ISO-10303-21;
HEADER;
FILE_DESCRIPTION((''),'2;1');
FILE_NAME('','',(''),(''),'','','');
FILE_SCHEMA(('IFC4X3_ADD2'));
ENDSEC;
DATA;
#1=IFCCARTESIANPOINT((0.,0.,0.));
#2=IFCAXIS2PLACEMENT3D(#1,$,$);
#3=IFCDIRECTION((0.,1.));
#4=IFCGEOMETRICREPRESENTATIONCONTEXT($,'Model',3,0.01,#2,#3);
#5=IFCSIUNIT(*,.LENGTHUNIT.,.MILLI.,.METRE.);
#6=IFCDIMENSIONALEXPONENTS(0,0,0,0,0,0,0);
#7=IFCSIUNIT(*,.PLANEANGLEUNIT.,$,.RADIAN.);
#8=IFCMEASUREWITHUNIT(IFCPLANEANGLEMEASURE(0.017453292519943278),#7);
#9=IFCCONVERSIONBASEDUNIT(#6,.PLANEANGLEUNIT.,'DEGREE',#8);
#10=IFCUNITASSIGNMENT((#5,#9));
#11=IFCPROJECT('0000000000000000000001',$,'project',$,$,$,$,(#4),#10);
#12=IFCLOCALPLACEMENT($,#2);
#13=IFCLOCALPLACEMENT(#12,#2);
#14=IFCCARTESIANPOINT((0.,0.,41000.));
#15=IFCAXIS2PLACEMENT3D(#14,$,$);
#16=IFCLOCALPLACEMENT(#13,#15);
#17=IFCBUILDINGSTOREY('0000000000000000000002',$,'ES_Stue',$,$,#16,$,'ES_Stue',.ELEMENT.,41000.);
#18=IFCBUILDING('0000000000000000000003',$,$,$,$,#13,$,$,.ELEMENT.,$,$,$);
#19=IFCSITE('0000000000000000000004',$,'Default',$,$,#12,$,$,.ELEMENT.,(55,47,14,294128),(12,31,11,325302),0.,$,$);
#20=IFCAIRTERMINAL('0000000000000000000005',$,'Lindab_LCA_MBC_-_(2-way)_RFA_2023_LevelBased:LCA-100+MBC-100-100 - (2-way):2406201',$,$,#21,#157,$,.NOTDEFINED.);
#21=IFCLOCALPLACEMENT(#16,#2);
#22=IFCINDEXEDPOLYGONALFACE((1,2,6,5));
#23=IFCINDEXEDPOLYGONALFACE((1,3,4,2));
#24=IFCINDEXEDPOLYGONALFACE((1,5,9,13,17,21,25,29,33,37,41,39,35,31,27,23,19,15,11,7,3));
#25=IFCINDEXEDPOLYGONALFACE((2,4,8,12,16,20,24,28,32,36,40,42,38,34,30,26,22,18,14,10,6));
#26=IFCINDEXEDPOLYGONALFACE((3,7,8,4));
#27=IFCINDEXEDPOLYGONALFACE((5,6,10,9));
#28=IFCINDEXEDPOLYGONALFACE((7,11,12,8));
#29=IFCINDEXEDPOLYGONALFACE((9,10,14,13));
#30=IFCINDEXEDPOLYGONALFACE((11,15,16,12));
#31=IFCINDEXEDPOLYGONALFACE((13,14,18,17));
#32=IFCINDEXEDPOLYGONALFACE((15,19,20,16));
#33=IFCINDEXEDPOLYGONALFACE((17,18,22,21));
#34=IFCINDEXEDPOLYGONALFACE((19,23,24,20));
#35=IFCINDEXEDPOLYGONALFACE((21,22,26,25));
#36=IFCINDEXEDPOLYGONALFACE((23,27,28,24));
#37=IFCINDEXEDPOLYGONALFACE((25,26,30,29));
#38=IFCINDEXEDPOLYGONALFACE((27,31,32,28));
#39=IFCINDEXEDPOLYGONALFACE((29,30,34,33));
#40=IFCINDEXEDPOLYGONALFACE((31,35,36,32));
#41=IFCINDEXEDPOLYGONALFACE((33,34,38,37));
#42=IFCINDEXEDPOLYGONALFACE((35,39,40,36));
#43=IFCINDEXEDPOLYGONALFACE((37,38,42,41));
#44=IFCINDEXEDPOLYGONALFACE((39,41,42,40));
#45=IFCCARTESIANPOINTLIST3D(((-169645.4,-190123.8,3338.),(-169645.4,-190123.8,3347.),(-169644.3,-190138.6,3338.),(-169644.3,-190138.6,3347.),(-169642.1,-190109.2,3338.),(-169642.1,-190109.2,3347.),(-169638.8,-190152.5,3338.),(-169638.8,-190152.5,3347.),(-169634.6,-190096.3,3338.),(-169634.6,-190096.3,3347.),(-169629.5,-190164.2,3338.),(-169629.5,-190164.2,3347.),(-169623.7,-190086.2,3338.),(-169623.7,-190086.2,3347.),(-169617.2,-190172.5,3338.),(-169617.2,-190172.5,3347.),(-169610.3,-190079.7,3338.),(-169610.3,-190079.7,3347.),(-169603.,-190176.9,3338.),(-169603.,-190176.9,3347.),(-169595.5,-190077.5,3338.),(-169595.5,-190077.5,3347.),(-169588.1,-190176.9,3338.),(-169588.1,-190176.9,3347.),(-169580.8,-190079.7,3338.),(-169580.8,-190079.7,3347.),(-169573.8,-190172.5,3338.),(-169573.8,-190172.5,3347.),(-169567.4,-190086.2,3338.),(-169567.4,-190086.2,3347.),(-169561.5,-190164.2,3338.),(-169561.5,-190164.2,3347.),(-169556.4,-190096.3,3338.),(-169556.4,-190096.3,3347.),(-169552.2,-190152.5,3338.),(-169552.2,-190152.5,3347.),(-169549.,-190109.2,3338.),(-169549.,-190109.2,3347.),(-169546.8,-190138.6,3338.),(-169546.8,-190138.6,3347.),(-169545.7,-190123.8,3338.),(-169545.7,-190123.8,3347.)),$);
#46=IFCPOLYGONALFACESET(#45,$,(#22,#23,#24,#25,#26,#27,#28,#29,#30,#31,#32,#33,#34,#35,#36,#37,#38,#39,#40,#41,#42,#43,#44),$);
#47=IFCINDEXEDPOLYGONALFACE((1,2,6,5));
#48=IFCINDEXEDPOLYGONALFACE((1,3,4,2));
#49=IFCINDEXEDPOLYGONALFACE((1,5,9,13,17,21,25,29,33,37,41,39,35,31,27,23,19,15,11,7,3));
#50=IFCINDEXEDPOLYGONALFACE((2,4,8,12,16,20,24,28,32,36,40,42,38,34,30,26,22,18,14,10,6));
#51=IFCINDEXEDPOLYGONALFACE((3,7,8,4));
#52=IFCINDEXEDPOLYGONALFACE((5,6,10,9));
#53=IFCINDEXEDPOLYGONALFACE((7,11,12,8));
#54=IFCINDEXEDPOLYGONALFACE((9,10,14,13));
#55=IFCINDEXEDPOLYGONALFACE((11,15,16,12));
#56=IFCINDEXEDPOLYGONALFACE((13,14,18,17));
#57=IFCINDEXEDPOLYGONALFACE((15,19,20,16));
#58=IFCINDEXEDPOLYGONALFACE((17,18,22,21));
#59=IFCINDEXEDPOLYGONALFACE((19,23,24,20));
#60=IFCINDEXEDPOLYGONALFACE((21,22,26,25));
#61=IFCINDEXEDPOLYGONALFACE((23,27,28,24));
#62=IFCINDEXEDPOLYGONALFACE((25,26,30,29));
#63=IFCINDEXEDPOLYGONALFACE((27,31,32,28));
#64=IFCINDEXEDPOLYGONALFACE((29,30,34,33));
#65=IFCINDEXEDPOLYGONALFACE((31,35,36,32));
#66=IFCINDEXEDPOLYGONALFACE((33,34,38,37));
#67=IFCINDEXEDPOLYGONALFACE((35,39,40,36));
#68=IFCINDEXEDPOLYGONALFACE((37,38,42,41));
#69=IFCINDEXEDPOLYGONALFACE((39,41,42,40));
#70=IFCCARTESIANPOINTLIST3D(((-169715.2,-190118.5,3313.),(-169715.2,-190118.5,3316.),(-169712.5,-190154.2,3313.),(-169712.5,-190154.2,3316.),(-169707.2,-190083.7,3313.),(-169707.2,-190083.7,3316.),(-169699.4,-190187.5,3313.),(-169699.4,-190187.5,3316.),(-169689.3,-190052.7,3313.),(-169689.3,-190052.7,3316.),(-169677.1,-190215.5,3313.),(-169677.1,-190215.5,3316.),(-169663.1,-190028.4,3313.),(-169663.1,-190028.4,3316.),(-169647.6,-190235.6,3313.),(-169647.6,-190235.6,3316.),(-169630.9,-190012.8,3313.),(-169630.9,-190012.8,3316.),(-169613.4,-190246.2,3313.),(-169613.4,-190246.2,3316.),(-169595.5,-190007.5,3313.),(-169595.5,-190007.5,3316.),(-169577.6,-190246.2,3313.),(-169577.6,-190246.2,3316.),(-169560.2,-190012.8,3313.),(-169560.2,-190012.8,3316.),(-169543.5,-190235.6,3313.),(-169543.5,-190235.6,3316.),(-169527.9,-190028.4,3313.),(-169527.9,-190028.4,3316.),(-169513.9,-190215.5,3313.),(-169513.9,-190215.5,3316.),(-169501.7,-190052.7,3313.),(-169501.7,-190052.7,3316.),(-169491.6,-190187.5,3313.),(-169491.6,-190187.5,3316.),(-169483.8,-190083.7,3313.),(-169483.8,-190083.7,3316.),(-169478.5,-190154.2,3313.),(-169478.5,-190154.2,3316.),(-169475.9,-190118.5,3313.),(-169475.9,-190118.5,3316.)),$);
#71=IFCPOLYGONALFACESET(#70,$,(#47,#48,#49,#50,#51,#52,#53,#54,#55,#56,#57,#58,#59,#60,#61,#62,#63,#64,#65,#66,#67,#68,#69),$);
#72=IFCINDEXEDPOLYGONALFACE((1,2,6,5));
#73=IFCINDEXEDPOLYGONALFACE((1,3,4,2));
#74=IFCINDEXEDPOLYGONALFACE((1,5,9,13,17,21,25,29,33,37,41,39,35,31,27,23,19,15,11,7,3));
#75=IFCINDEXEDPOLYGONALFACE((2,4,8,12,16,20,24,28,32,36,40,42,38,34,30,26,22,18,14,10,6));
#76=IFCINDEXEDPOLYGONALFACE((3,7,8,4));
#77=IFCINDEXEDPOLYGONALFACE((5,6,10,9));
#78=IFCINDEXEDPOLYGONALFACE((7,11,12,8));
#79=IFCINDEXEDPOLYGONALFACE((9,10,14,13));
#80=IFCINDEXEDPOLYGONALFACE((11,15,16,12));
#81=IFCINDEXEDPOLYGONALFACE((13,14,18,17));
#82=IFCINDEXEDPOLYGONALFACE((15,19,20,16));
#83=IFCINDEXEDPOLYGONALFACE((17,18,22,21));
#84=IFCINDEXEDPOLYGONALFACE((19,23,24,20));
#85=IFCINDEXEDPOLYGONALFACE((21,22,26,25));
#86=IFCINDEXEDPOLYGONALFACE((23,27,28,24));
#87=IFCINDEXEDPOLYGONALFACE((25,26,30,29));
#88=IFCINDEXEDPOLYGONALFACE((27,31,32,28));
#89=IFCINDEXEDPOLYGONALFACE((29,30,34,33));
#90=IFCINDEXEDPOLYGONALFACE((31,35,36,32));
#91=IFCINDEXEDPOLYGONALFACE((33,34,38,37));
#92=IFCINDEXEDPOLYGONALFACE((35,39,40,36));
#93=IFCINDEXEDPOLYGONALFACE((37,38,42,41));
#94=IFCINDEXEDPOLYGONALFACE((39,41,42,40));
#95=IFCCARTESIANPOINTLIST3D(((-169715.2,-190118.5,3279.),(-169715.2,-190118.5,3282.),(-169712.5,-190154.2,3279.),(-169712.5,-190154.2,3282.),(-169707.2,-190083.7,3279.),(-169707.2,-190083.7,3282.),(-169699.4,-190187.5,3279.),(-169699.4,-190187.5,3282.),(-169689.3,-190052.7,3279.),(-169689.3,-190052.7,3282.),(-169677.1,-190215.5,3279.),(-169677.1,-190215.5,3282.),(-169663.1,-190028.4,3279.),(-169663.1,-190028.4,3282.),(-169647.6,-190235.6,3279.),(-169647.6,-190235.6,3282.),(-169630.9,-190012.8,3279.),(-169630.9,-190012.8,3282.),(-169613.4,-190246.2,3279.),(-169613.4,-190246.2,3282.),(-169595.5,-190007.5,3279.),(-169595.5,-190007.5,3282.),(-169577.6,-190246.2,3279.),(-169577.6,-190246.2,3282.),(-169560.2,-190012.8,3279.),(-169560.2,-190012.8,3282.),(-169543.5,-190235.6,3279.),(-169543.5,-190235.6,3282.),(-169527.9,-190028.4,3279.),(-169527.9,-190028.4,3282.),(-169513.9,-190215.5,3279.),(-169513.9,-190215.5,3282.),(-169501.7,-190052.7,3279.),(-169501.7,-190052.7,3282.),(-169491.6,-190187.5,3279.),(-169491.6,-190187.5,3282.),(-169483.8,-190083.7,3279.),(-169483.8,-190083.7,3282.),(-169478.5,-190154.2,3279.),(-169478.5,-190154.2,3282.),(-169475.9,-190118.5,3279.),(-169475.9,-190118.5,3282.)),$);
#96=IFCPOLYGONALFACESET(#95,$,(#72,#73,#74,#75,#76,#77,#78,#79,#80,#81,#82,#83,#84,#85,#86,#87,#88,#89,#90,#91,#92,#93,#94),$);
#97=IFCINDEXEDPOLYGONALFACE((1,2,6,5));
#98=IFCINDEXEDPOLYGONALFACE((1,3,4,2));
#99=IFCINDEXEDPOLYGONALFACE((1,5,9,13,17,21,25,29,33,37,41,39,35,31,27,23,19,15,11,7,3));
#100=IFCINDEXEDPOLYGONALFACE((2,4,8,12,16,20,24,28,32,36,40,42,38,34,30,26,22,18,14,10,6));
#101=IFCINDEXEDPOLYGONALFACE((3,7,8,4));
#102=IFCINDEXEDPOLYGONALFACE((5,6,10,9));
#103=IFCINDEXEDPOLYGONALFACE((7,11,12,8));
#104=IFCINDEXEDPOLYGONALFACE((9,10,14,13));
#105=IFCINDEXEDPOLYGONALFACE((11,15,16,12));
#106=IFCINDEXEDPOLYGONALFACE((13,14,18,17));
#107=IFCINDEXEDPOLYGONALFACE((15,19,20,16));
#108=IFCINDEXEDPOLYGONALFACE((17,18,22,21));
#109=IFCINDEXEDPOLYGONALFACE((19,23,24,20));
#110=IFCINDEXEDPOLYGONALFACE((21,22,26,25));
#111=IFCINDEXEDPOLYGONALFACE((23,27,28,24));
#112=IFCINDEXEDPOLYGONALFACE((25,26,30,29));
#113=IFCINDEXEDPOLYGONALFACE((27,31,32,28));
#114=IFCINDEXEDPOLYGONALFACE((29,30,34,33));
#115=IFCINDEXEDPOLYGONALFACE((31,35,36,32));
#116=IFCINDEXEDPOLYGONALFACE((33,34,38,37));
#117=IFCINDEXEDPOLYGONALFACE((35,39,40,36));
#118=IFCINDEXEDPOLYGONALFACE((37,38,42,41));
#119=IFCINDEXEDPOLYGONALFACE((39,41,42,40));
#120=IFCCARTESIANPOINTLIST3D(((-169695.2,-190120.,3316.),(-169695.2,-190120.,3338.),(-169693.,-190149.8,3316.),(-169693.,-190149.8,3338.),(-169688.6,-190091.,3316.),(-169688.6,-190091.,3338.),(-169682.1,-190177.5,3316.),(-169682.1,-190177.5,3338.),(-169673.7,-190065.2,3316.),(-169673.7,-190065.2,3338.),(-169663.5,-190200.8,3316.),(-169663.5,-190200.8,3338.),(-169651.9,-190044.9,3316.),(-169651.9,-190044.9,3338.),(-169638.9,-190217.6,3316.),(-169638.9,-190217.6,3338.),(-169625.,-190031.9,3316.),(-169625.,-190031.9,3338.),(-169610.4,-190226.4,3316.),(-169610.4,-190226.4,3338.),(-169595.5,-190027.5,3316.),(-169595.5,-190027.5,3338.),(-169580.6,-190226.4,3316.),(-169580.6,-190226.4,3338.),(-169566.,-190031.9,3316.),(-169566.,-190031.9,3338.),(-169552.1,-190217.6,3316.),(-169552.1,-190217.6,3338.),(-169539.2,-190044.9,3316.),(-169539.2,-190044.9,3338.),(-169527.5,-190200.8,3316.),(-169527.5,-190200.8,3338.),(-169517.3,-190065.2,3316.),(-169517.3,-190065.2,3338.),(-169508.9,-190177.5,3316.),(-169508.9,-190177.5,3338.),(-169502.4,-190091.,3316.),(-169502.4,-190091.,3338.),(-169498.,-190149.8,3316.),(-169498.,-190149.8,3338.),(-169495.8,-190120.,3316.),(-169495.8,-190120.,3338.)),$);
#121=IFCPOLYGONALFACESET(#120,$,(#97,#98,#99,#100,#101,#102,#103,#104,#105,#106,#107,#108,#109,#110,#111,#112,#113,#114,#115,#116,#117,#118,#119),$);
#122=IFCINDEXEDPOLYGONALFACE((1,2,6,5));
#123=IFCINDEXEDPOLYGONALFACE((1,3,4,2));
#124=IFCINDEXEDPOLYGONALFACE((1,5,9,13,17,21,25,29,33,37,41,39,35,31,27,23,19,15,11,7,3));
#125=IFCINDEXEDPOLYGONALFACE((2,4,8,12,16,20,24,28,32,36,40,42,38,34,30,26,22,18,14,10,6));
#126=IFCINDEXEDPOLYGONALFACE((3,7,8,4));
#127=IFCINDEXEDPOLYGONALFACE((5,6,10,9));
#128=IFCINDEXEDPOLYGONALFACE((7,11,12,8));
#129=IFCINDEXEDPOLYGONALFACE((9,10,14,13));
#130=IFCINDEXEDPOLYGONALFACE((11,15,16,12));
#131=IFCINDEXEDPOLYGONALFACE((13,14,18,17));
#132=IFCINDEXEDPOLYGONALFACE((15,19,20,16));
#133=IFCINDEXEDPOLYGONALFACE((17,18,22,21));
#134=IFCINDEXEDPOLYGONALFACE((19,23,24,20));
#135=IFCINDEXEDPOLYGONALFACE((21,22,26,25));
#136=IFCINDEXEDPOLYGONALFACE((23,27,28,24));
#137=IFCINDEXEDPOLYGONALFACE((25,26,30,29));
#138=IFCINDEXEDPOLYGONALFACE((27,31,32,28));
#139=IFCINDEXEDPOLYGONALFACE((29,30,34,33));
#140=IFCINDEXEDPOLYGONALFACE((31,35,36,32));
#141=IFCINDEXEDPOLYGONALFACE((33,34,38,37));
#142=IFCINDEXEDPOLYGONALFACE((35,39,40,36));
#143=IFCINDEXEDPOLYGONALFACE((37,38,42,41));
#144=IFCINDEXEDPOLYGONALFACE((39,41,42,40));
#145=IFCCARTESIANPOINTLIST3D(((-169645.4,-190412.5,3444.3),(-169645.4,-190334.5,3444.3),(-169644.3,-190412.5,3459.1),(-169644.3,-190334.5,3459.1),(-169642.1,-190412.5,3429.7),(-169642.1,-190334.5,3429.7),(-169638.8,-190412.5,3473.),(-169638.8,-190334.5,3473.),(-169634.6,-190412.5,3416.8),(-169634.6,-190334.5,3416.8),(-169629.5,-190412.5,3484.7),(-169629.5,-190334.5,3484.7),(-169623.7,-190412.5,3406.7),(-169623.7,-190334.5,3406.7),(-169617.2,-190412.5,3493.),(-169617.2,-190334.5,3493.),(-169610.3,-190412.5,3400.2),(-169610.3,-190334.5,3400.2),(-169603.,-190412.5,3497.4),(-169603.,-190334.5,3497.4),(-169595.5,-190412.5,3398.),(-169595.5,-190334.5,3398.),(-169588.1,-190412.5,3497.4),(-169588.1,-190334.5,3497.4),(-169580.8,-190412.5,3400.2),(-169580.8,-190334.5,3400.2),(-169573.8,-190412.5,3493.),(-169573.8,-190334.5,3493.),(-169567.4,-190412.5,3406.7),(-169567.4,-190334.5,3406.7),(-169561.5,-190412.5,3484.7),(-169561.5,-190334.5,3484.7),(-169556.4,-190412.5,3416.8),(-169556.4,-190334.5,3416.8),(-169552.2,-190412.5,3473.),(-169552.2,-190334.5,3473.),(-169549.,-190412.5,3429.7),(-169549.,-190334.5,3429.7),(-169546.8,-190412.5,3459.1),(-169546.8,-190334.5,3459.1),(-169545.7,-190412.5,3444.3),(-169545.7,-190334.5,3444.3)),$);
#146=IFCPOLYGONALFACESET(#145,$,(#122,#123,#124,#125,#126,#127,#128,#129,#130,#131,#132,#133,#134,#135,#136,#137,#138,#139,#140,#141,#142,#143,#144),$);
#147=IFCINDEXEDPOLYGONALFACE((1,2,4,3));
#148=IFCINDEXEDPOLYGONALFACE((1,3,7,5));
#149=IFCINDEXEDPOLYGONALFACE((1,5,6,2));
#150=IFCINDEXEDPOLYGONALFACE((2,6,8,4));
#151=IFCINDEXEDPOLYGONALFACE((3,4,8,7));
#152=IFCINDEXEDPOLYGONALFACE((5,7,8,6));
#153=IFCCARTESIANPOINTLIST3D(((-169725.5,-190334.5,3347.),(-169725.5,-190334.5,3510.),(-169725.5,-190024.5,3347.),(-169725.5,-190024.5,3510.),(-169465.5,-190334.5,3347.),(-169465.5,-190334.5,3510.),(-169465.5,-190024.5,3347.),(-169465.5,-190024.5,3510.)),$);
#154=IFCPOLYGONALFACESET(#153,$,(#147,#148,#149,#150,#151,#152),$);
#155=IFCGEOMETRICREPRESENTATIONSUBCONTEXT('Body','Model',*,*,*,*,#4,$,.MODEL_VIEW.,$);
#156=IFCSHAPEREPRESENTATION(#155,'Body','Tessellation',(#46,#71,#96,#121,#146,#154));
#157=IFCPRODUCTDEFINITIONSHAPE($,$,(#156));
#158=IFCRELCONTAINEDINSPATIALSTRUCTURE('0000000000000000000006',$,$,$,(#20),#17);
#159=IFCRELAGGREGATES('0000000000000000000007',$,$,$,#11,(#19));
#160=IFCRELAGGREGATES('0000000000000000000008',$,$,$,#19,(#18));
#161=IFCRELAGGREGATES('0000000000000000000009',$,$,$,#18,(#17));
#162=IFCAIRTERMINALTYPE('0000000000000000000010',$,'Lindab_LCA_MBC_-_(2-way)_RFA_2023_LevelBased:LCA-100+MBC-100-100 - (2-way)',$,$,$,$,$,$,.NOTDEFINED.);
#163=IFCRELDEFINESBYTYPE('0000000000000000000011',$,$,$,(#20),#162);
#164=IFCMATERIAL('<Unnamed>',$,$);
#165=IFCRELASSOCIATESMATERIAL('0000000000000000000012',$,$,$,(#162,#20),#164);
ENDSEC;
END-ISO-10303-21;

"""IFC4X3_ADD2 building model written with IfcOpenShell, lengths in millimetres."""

from ifc_helpers import new_model, entity, si_unit, converted_unit, direction, frame, frame_2d, origin, origin_2d_with_axis, place, context, subcontext, project, spatial, rectangle, circle, extrude, source, transform, mapped, material, type_object, type_shapes, element, save


model = new_model("IFC4X3_ADD2")

# Units and contexts
model_context = context("Model", 3, precision=0.01, world=origin(), true_north=direction((0.0, 1.0)))
body_context = subcontext(model_context, "Body", "Model", "MODEL_VIEW")
ifc_project = project(units=[si_unit("LENGTHUNIT", "METRE", prefix="MILLI"), converted_unit("PLANEANGLEUNIT", "DEGREE", entity("IfcPlaneAngleMeasure", 0.017453292519943278), si_unit("PLANEANGLEUNIT", "RADIAN"), dimensions=[0, 0, 0, 0, 0, 0, 0])], contexts=[model_context])

# Site, building, storey
site_placement = place(None, origin())
site = spatial("IfcSite", under=ifc_project, at=site_placement, Name="Default", CompositionType="ELEMENT", RefLatitude=(55, 47, 14, 294128), RefLongitude=(12, 31, 11, 325302), RefElevation=0.0)
building_placement = place(site_placement, origin())
building = spatial("IfcBuilding", under=site, at=building_placement, CompositionType="ELEMENT")
storey_placement = place(building_placement, frame((0.0, 0.0, 41000.0)))
storey = spatial("IfcBuildingStorey", under=building, at=storey_placement, Name="ES_Stue", LongName="ES_Stue", CompositionType="ELEMENT", Elevation=41000.0)

# Air terminal
ifc_material_1 = material(Name="<Unnamed>")
air_terminal_type = type_object("IfcAirTerminalType", Name="Lindab_LCA_MBC_-_(2-way)_RFA_2023_LevelBased:LCA-100+MBC-100-100 - (2-way)", PredefinedType="NOTDEFINED", material=ifc_material_1)
shared_shape_1 = source(origin(), body_context, "Body", "SweptSolid", [
    extrude(circle(Radius=50.0, at=frame_2d((0.0, 0.0), x_axis=(1.0, 0.0))), frame((0.0, 0.0, 22.0)), (0.0, 0.0, 1.0), 9.0),
    extrude(circle(Radius=120.0, at=frame_2d((0.0, 0.0), x_axis=(1.0, 0.0))), frame((0.0, 0.0, -3.0)), (0.0, 0.0, 1.0), 3.0),
    extrude(circle(Radius=120.0, at=frame_2d((0.0, 0.0), x_axis=(1.0, 0.0))), frame((0.0, 0.0, -37.0)), (0.0, 0.0, 1.0), 3.0),
    extrude(circle(Radius=100.0, at=frame_2d((0.0, 0.0), x_axis=(1.0, 0.0))), origin(), (0.0, 0.0, 1.0), 22.0),
    extrude(circle(Radius=50.0, at=frame_2d((0.0, 0.0), x_axis=(1.0, 0.0))), frame((-285.0, 0.0, 132.0), z_axis=(1.0, 0.0, 0.0), x_axis=(0.0, 0.0, -1.0)), (0.0, 0.0, 1.0), 78.0),
    extrude(rectangle(XDim=260.0, YDim=310.0, at=origin_2d_with_axis()), frame((-52.0, 0.0, 31.0), z_axis=(0.0, 0.0, 1.0), x_axis=(0.0, -1.0, 0.0)), (0.0, 0.0, 1.0), 163.0),
])
type_shapes(air_terminal_type, [shared_shape_1])
for number, where, z_axis, x_axis, name in (
    (1, (-169595.5, -190127.5, 3316.0), (0.0, 0.0, 1.0), (0.0, 1.0, 0.0), "Lindab_LCA_MBC_-_(2-way)_RFA_2023_LevelBased:LCA-100+MBC-100-100 - (2-way):2406201"),
):
    element("IfcAirTerminal", number, at=place(storey_placement, frame(where, z_axis=z_axis, x_axis=x_axis)), inside=storey, type_object=air_terminal_type, material=ifc_material_1, Name=name, PredefinedType="NOTDEFINED", context=body_context, shape_type="MappedRepresentation", body=[
        mapped(shared_shape_1, transform((0.0, 0.0, 0.0), scale=1.0)),
    ])

save(model, "model.ifc")
